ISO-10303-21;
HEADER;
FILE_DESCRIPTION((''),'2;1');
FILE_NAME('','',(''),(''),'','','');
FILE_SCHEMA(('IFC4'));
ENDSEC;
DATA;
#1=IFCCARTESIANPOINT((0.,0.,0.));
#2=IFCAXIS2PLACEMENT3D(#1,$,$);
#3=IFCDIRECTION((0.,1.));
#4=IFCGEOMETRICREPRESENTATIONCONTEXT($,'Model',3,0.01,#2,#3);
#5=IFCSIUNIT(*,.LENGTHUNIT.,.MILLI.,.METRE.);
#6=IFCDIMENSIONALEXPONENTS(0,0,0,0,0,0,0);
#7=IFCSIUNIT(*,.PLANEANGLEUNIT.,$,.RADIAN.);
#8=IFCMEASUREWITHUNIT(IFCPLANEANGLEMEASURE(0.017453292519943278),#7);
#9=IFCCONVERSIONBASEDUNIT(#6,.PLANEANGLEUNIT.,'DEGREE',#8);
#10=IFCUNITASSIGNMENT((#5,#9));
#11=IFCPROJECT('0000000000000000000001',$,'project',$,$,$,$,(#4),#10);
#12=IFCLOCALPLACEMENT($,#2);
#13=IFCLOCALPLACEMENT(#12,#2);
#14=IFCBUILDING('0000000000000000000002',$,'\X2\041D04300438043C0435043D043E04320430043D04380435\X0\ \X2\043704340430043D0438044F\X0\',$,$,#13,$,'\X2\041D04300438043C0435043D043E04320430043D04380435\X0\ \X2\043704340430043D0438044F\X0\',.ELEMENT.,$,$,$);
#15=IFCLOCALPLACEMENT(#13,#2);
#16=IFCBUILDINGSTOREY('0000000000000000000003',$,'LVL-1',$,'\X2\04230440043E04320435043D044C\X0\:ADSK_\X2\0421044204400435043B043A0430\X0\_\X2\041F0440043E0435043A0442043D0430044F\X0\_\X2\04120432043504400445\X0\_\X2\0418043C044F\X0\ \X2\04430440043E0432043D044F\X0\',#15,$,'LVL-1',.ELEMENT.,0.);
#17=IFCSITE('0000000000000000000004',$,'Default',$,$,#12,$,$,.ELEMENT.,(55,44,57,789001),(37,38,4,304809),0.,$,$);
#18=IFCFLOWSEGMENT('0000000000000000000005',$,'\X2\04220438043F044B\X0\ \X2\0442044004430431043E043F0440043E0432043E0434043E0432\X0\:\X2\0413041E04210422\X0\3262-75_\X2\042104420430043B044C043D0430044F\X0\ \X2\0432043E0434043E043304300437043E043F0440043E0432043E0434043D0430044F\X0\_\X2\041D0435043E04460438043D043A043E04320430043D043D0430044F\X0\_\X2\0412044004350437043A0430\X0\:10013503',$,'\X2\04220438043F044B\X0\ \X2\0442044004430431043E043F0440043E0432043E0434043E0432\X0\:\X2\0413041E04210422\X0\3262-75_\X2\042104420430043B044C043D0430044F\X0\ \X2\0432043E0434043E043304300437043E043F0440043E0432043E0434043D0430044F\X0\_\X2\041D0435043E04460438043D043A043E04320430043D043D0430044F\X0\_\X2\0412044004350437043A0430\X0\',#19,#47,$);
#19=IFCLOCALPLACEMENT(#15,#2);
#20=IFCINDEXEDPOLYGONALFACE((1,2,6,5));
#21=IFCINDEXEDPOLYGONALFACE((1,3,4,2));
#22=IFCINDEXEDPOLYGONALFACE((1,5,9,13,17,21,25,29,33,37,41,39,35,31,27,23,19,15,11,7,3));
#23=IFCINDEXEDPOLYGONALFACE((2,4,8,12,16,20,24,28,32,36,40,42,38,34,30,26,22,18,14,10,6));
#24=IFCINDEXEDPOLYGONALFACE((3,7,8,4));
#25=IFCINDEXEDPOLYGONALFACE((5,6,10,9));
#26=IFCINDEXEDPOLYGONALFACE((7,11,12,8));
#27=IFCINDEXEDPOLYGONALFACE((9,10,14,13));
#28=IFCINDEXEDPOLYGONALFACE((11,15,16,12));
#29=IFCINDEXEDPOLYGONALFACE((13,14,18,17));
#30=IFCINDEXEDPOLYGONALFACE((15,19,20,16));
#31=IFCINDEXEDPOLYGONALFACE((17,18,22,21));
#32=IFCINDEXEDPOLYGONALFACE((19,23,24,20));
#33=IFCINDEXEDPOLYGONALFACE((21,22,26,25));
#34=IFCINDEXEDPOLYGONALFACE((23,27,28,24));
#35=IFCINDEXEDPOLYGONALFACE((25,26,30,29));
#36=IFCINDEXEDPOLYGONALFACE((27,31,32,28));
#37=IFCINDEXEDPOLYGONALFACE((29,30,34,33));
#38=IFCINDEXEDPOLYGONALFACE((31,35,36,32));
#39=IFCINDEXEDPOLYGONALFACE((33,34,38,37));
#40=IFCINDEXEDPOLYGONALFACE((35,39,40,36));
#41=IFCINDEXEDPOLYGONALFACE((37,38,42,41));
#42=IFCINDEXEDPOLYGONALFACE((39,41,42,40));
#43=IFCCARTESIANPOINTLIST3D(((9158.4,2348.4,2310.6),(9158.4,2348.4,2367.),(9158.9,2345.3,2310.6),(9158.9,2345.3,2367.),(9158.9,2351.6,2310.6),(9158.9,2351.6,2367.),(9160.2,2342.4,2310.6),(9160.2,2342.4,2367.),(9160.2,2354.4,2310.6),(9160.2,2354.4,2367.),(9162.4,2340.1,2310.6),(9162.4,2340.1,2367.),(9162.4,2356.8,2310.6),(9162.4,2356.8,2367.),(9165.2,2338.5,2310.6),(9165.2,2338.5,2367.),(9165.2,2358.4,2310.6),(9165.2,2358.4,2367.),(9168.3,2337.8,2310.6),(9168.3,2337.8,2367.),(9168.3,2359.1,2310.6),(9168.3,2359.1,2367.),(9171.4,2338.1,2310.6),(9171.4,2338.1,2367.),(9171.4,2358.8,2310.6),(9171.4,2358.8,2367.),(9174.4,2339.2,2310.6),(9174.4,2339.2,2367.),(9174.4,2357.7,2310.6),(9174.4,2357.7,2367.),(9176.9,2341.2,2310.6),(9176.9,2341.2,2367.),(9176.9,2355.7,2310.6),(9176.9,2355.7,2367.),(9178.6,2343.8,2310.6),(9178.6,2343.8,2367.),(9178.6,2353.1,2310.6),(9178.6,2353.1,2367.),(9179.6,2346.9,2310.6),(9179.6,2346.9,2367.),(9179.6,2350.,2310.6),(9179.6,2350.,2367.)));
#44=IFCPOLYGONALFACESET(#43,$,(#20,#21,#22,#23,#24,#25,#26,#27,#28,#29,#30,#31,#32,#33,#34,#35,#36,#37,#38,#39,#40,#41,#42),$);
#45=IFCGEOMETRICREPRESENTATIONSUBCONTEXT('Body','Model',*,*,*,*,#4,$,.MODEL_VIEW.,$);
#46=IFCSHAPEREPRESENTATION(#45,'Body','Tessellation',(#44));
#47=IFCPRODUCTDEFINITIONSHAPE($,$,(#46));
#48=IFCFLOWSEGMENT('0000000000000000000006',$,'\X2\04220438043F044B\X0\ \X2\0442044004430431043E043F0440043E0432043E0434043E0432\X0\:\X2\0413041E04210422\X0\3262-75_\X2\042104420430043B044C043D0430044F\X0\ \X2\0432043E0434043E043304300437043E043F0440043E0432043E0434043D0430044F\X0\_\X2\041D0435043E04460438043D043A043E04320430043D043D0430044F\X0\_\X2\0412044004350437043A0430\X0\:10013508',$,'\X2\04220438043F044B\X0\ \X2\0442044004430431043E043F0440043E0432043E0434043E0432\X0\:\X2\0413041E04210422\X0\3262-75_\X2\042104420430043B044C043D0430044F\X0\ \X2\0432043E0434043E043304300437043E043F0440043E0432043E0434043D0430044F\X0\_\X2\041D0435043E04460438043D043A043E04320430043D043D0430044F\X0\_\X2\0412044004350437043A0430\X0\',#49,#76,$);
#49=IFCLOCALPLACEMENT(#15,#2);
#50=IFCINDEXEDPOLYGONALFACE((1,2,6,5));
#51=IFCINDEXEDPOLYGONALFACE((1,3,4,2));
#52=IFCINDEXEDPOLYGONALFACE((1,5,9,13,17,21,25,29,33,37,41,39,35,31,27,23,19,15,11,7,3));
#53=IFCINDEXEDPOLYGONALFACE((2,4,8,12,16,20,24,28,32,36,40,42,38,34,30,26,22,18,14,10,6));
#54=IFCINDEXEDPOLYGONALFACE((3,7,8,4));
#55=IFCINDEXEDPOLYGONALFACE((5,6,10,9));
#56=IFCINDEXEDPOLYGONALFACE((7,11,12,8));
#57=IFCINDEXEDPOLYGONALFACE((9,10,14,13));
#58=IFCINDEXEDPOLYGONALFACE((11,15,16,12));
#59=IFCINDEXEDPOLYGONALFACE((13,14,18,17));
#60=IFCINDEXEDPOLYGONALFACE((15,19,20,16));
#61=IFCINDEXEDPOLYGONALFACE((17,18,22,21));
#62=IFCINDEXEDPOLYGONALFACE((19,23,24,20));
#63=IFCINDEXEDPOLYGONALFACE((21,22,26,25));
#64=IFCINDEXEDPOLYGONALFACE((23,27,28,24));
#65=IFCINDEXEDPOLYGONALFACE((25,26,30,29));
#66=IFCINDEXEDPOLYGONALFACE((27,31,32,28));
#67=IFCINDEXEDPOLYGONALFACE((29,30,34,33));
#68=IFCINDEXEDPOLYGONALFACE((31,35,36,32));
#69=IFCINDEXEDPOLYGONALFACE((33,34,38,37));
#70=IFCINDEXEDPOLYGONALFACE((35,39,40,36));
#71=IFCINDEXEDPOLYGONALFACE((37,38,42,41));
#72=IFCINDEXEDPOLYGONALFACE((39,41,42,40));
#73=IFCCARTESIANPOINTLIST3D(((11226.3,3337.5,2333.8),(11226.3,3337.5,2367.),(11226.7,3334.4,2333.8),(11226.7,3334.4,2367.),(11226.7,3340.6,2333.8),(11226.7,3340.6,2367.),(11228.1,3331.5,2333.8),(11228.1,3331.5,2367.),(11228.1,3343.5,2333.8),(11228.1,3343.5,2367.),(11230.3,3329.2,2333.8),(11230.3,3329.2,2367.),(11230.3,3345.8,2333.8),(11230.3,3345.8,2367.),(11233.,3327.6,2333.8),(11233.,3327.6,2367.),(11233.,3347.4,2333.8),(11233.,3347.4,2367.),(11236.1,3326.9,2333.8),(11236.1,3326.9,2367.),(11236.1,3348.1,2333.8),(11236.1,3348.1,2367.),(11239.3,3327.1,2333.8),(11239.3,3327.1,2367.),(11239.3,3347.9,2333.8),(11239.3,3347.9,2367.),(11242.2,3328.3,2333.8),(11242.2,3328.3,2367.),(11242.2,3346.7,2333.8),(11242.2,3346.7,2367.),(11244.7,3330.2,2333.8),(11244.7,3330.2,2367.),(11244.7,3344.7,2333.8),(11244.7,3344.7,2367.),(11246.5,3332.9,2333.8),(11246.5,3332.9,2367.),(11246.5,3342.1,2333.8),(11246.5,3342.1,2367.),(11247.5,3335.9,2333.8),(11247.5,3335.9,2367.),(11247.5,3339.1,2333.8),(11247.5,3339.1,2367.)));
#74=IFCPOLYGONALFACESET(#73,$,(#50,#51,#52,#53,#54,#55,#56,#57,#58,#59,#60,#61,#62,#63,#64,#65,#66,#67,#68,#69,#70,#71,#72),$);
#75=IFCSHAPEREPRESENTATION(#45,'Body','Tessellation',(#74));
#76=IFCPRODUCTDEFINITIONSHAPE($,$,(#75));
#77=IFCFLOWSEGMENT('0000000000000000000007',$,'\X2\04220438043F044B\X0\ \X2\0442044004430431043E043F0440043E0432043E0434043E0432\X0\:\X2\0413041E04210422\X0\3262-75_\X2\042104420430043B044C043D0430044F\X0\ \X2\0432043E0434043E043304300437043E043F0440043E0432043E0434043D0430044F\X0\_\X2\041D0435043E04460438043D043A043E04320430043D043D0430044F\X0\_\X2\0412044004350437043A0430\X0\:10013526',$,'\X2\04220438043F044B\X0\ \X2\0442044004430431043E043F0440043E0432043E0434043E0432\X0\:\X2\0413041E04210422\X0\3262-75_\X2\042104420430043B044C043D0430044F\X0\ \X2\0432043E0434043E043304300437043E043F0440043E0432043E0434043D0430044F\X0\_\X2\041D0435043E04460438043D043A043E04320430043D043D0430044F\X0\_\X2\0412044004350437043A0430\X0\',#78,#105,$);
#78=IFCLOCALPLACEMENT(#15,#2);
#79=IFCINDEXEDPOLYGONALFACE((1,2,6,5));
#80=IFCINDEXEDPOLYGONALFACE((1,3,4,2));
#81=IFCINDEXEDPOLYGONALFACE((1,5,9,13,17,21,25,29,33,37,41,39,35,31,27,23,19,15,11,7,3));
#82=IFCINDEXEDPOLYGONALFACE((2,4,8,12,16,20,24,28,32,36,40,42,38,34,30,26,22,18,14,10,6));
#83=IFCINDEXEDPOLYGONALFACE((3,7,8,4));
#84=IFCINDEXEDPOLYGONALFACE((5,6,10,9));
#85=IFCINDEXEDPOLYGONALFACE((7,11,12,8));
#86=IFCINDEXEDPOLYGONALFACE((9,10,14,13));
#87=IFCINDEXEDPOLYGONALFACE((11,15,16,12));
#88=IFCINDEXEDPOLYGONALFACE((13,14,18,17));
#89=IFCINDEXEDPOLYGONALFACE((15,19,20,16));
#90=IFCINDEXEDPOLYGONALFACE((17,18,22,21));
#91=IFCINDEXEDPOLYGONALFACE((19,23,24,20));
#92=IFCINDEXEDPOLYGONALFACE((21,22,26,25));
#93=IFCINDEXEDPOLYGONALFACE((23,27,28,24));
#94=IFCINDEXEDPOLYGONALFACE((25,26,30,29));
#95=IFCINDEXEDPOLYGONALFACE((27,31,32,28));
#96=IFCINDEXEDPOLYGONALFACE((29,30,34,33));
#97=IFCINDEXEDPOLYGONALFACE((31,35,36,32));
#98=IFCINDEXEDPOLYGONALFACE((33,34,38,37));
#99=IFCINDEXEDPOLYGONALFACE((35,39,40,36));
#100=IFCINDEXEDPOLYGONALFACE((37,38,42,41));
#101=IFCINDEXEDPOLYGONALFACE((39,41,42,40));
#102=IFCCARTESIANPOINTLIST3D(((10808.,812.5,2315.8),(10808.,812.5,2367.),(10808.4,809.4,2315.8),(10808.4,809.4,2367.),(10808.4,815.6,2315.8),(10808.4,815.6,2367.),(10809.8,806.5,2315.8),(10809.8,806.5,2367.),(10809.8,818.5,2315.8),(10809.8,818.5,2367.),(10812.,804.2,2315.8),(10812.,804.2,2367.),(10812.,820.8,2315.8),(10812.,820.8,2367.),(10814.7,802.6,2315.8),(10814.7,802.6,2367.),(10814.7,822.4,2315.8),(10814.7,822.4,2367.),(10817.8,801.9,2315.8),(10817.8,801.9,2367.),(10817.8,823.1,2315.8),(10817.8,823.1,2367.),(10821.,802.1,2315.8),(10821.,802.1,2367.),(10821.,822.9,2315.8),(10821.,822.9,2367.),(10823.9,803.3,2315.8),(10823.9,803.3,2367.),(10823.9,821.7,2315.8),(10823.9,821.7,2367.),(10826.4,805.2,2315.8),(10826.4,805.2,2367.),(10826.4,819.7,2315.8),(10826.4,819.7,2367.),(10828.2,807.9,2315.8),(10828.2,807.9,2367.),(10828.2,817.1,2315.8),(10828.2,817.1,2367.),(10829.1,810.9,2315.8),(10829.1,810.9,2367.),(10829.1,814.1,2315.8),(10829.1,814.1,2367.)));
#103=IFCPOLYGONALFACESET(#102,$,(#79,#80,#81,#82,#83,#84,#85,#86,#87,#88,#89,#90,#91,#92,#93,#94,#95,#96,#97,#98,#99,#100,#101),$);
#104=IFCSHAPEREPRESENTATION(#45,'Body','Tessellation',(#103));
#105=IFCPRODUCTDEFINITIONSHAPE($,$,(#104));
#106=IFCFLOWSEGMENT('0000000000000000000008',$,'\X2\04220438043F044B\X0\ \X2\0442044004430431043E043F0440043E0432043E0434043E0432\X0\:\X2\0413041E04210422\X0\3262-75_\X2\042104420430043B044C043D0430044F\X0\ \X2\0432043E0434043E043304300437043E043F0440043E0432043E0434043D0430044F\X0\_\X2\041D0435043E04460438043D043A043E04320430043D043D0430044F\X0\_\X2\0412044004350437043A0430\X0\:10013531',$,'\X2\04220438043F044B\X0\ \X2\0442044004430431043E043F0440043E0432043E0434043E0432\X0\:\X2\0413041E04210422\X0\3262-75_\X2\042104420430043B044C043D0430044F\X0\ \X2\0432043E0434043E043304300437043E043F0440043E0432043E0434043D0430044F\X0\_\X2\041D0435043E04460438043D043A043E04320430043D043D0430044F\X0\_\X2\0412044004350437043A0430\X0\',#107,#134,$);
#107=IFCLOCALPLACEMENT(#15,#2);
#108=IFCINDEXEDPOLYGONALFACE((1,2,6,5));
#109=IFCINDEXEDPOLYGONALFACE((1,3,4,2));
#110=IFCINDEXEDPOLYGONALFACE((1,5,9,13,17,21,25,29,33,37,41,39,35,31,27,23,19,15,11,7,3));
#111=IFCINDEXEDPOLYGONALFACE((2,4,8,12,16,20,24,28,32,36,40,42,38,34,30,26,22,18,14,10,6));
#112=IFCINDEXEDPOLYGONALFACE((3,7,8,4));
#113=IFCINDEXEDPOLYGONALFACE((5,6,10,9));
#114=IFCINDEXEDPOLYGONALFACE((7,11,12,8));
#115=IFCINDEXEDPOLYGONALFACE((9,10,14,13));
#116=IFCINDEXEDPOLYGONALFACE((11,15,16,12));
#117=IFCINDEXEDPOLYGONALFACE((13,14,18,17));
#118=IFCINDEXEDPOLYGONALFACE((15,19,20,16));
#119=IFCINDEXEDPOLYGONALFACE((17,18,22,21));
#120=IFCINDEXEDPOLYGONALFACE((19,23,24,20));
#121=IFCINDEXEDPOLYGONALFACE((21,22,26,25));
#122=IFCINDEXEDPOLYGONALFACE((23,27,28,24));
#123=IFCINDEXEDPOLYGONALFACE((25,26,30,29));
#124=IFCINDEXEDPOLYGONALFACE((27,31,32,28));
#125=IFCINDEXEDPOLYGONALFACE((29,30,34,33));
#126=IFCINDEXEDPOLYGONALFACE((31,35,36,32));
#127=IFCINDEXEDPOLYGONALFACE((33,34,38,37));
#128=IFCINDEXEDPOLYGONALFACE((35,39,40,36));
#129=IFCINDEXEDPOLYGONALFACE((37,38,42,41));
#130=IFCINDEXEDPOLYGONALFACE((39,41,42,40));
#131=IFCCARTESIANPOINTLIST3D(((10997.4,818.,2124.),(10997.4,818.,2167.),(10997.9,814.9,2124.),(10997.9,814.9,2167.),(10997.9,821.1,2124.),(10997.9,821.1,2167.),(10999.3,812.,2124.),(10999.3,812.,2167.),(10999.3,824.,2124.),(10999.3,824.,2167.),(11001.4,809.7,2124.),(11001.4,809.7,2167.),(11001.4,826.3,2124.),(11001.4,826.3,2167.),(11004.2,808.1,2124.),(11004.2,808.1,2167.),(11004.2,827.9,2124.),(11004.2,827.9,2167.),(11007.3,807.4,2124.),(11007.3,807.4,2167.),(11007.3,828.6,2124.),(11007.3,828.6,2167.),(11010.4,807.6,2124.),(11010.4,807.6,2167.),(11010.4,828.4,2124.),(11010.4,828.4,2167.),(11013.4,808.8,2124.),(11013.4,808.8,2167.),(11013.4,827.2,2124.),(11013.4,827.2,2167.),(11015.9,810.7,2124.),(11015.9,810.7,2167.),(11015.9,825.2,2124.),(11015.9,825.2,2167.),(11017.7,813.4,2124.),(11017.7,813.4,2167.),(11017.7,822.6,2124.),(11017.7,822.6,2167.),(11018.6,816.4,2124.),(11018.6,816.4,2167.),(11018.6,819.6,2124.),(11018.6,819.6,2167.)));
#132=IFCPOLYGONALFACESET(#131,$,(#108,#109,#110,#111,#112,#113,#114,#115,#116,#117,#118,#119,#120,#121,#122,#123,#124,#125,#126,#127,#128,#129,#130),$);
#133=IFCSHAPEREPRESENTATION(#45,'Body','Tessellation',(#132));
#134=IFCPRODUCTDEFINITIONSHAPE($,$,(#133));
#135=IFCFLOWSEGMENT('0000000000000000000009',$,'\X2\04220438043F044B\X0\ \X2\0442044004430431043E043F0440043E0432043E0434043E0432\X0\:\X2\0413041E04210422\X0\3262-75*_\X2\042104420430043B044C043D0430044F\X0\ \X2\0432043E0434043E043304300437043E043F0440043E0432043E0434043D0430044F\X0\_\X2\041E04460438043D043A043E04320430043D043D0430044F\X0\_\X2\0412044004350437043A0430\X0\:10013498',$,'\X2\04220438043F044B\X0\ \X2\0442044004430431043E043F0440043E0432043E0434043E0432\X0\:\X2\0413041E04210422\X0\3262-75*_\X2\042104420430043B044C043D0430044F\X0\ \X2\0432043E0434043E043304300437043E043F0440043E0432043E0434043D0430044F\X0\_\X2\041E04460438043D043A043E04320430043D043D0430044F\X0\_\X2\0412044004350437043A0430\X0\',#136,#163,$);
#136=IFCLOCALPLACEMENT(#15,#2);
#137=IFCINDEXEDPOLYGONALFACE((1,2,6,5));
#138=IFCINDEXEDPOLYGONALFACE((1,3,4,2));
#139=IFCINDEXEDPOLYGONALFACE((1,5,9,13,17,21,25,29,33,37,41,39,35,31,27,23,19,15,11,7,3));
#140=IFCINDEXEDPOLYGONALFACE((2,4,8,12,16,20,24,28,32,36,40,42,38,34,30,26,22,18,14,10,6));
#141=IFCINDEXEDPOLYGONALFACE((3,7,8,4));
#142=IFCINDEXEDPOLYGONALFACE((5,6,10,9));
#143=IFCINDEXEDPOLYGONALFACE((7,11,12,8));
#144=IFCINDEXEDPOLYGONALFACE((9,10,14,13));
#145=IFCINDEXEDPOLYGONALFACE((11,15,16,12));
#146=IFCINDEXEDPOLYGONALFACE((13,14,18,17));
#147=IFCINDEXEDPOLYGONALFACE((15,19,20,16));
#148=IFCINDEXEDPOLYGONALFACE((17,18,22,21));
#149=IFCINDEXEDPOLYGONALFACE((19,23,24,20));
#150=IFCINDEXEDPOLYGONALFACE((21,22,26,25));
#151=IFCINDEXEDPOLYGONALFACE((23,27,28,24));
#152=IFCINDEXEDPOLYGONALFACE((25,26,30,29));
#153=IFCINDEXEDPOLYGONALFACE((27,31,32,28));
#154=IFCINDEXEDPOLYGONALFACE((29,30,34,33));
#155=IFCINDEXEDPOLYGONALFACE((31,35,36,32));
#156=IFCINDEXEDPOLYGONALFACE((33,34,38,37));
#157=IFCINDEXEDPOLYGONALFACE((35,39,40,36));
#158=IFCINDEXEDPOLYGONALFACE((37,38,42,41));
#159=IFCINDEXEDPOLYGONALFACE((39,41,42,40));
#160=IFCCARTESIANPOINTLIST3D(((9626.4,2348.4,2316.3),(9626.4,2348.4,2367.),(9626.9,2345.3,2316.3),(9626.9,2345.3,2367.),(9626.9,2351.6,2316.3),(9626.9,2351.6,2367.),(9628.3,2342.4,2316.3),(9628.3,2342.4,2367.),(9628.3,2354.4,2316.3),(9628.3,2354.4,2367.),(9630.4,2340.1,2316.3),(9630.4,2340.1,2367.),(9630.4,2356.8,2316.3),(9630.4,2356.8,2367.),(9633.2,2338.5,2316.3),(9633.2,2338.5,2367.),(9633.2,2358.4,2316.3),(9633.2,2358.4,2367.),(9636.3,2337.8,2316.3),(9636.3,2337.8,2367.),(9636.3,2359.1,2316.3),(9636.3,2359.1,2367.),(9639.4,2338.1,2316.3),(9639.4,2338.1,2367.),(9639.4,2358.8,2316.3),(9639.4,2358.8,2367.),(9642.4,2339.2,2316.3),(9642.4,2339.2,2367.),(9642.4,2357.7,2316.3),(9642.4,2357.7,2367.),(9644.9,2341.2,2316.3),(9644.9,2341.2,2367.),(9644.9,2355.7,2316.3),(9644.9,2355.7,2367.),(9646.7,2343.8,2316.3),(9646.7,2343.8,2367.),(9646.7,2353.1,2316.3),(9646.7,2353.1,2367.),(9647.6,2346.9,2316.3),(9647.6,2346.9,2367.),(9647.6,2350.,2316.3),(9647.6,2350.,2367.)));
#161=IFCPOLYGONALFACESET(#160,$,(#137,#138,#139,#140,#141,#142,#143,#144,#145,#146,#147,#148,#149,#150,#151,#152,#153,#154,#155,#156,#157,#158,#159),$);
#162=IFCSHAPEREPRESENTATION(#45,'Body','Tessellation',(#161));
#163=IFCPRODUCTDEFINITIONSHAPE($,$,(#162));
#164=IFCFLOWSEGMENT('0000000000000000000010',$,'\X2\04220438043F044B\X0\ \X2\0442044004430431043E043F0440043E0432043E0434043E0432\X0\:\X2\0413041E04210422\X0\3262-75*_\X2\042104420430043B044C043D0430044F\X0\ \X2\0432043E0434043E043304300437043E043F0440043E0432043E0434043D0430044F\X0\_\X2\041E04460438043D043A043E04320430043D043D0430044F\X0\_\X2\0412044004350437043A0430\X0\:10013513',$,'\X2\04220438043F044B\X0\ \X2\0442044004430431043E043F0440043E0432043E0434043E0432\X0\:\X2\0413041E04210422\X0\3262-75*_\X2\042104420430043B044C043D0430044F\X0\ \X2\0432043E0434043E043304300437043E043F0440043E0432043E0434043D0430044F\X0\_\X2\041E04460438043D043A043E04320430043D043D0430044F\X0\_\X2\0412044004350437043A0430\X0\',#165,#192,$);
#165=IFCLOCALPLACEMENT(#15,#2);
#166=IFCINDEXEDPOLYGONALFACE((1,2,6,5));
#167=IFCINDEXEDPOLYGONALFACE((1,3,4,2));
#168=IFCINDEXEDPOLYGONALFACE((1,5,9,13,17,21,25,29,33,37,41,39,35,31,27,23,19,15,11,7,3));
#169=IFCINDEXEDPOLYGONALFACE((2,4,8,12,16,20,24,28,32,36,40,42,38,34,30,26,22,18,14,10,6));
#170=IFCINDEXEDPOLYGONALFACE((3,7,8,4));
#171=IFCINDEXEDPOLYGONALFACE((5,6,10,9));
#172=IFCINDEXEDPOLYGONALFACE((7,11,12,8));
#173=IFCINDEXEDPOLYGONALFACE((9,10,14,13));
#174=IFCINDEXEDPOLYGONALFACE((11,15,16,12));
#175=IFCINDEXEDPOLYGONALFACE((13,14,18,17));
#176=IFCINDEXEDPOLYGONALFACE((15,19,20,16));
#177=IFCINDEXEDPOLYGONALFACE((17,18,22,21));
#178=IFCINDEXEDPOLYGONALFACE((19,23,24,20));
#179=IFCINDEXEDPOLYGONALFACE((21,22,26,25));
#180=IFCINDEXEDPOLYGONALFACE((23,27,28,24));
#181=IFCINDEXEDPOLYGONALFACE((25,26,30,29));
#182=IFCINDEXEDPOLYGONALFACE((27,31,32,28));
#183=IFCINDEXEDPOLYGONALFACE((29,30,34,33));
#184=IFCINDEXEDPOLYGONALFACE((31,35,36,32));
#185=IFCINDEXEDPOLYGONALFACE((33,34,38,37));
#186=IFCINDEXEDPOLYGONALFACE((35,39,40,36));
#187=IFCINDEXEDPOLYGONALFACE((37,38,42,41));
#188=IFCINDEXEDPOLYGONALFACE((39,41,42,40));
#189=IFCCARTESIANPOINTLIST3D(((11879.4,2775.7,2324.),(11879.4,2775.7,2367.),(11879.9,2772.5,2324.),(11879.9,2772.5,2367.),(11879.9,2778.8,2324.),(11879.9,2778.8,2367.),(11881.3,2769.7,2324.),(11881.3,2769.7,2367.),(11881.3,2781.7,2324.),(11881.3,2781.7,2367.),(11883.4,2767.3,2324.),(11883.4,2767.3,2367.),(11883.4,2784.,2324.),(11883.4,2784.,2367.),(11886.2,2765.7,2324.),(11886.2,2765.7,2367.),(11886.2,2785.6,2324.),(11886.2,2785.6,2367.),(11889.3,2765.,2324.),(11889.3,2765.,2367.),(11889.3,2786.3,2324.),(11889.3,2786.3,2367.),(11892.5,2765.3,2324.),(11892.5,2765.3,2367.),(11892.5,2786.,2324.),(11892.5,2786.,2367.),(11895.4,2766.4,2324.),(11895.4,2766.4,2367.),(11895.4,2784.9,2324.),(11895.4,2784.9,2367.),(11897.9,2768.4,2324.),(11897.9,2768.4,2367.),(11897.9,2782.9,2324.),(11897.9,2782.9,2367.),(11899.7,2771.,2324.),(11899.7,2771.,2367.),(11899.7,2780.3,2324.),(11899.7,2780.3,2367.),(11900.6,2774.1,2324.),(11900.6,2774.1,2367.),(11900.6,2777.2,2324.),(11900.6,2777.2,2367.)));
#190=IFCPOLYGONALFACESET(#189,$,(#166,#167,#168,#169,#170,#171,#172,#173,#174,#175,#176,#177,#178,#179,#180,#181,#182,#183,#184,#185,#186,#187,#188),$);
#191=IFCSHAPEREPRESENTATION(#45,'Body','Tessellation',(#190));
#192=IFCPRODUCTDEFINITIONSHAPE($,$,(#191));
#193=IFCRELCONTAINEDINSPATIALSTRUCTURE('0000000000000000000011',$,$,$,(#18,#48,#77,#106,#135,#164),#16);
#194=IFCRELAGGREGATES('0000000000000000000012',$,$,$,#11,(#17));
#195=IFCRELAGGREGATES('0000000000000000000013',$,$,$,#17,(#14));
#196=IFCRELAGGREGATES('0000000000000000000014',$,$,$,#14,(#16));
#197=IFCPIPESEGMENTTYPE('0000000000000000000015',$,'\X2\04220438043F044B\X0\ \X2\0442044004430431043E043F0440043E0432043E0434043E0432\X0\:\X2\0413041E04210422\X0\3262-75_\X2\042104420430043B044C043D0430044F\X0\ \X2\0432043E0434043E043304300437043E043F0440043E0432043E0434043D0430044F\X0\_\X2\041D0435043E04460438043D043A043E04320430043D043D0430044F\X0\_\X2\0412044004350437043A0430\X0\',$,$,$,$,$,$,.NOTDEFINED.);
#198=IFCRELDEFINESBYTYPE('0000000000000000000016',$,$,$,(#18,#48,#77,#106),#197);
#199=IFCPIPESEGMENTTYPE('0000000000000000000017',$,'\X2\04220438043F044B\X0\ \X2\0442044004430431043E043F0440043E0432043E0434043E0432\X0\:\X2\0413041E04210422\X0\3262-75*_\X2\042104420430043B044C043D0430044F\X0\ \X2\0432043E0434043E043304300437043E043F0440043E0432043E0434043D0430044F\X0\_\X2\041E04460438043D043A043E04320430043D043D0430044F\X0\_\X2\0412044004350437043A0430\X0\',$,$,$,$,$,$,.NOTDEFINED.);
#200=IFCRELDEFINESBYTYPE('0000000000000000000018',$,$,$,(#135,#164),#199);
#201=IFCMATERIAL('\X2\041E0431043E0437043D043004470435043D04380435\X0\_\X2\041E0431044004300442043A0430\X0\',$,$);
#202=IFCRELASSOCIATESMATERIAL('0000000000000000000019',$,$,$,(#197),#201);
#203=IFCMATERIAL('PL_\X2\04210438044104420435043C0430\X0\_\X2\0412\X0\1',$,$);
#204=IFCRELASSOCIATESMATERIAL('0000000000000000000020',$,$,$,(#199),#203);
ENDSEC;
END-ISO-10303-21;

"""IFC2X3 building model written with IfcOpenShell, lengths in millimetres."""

from ifc_helpers import new_model, entity, si_unit, converted_unit, direction, frame, frame_2d, origin, origin_2d_with_axis, place, context, subcontext, project, spatial, circle, extrude, material, type_object, element, save


model = new_model("IFC2X3")

# Units and contexts
model_context = context("Model", 3, precision=0.01, world=origin(), true_north=direction((0.0, 1.0)))
body_context = subcontext(model_context, "Body", "Model", "MODEL_VIEW")
ifc_project = project(units=[si_unit("LENGTHUNIT", "METRE", prefix="MILLI"), converted_unit("PLANEANGLEUNIT", "DEGREE", entity("IfcPlaneAngleMeasure", 0.017453292519943278), si_unit("PLANEANGLEUNIT", "RADIAN"), dimensions=[0, 0, 0, 0, 0, 0, 0])], contexts=[model_context])

# Site, building, storey
site_placement = place(None, origin())
site = spatial("IfcSite", under=ifc_project, at=site_placement, Name="Default", CompositionType="ELEMENT", RefLatitude=(55, 44, 57, 789001), RefLongitude=(37, 38, 4, 304809), RefElevation=0.0)
building_placement = place(site_placement, origin())
building = spatial("IfcBuilding", under=site, at=building_placement, Name="Наименование здания", LongName="Наименование здания", CompositionType="ELEMENT")
storey_placement = place(building_placement, origin())
storey = spatial("IfcBuildingStorey", under=building, at=storey_placement, Name="LVL-1", ObjectType="Уровень:ADSK_Стрелка_Проектная_Вверх_Имя уровня", LongName="LVL-1", CompositionType="ELEMENT", Elevation=0.0)

# Flow segments
ifc_material_1 = material(Name="Обозначение_Обратка")
pipe_segment_type_1 = type_object("IfcPipeSegmentType", Name="Типы трубопроводов:ГОСТ3262-75_Стальная водогазопроводная_Неоцинкованная_Врезка", PredefinedType="NOTDEFINED", material=ifc_material_1)
flow_segment_1_placement = place(storey_placement, origin())
element("IfcFlowSegment", 1, at=flow_segment_1_placement, inside=storey, type_object=pipe_segment_type_1, Name="Типы трубопроводов:ГОСТ3262-75_Стальная водогазопроводная_Неоцинкованная_Врезка:10013503", ObjectType="Типы трубопроводов:ГОСТ3262-75_Стальная водогазопроводная_Неоцинкованная_Врезка", context=body_context, shape_type="SweptSolid", body=[
    extrude(circle(Radius=10.7, at=origin_2d_with_axis()), frame((9169.0, 2348.4, 2310.6), z_axis=(0.0, 0.0, 1.0), x_axis=(-1.0, 0.0, 0.0)), (0.0, 0.0, 1.0), 56.4),
])
flow_segment_2_placement = place(storey_placement, origin())
element("IfcFlowSegment", 2, at=flow_segment_2_placement, inside=storey, type_object=pipe_segment_type_1, Name="Типы трубопроводов:ГОСТ3262-75_Стальная водогазопроводная_Неоцинкованная_Врезка:10013508", ObjectType="Типы трубопроводов:ГОСТ3262-75_Стальная водогазопроводная_Неоцинкованная_Врезка", context=body_context, shape_type="SweptSolid", body=[
    extrude(circle(Radius=10.7, at=origin_2d_with_axis()), frame((11236.9, 3337.5, 2333.8), z_axis=(0.0, 0.0, 1.0), x_axis=(-1.0, 0.0, 0.0)), (0.0, 0.0, 1.0), 33.2),
])
flow_segment_3_placement = place(storey_placement, origin())
element("IfcFlowSegment", 3, at=flow_segment_3_placement, inside=storey, type_object=pipe_segment_type_1, Name="Типы трубопроводов:ГОСТ3262-75_Стальная водогазопроводная_Неоцинкованная_Врезка:10013526", ObjectType="Типы трубопроводов:ГОСТ3262-75_Стальная водогазопроводная_Неоцинкованная_Врезка", context=body_context, shape_type="SweptSolid", body=[
    extrude(circle(Radius=10.7, at=origin_2d_with_axis()), frame((10818.6, 812.5, 2315.8), z_axis=(0.0, 0.0, 1.0), x_axis=(-1.0, 0.0, 0.0)), (0.0, 0.0, 1.0), 51.2),
])
flow_segment_4_placement = place(storey_placement, origin())
element("IfcFlowSegment", 4, at=flow_segment_4_placement, inside=storey, type_object=pipe_segment_type_1, Name="Типы трубопроводов:ГОСТ3262-75_Стальная водогазопроводная_Неоцинкованная_Врезка:10013531", ObjectType="Типы трубопроводов:ГОСТ3262-75_Стальная водогазопроводная_Неоцинкованная_Врезка", context=body_context, shape_type="SweptSolid", body=[
    extrude(circle(Radius=10.7, at=origin_2d_with_axis()), frame((11008.1, 818.0, 2124.0), z_axis=(0.0, 0.0, 1.0), x_axis=(-1.0, 0.0, 0.0)), (0.0, 0.0, 1.0), 43.0),
])
ifc_material_2 = material(Name="PL_Система_В1")
pipe_segment_type_2 = type_object("IfcPipeSegmentType", Name="Типы трубопроводов:ГОСТ3262-75*_Стальная водогазопроводная_Оцинкованная_Врезка", PredefinedType="NOTDEFINED", material=ifc_material_2)
flow_segment_5_placement = place(storey_placement, origin())
element("IfcFlowSegment", 5, at=flow_segment_5_placement, inside=storey, type_object=pipe_segment_type_2, Name="Типы трубопроводов:ГОСТ3262-75*_Стальная водогазопроводная_Оцинкованная_Врезка:10013498", ObjectType="Типы трубопроводов:ГОСТ3262-75*_Стальная водогазопроводная_Оцинкованная_Врезка", context=body_context, shape_type="SweptSolid", body=[
    extrude(circle(Radius=10.7, at=frame_2d((0.0, 0.0), x_axis=(1.0, 0.0))), frame((9637.1, 2348.4, 2316.3), z_axis=(0.0, 0.0, 1.0), x_axis=(-1.0, 0.0, 0.0)), (0.0, 0.0, 1.0), 50.7),
])
flow_segment_6_placement = place(storey_placement, origin())
element("IfcFlowSegment", 6, at=flow_segment_6_placement, inside=storey, type_object=pipe_segment_type_2, Name="Типы трубопроводов:ГОСТ3262-75*_Стальная водогазопроводная_Оцинкованная_Врезка:10013513", ObjectType="Типы трубопроводов:ГОСТ3262-75*_Стальная водогазопроводная_Оцинкованная_Врезка", context=body_context, shape_type="SweptSolid", body=[
    extrude(circle(Radius=10.7, at=origin_2d_with_axis()), frame((11890.1, 2775.7, 2324.0), z_axis=(0.0, 0.0, 1.0), x_axis=(-1.0, 0.0, 0.0)), (0.0, 0.0, 1.0), 43.0),
])

save(model, "model.ifc")
